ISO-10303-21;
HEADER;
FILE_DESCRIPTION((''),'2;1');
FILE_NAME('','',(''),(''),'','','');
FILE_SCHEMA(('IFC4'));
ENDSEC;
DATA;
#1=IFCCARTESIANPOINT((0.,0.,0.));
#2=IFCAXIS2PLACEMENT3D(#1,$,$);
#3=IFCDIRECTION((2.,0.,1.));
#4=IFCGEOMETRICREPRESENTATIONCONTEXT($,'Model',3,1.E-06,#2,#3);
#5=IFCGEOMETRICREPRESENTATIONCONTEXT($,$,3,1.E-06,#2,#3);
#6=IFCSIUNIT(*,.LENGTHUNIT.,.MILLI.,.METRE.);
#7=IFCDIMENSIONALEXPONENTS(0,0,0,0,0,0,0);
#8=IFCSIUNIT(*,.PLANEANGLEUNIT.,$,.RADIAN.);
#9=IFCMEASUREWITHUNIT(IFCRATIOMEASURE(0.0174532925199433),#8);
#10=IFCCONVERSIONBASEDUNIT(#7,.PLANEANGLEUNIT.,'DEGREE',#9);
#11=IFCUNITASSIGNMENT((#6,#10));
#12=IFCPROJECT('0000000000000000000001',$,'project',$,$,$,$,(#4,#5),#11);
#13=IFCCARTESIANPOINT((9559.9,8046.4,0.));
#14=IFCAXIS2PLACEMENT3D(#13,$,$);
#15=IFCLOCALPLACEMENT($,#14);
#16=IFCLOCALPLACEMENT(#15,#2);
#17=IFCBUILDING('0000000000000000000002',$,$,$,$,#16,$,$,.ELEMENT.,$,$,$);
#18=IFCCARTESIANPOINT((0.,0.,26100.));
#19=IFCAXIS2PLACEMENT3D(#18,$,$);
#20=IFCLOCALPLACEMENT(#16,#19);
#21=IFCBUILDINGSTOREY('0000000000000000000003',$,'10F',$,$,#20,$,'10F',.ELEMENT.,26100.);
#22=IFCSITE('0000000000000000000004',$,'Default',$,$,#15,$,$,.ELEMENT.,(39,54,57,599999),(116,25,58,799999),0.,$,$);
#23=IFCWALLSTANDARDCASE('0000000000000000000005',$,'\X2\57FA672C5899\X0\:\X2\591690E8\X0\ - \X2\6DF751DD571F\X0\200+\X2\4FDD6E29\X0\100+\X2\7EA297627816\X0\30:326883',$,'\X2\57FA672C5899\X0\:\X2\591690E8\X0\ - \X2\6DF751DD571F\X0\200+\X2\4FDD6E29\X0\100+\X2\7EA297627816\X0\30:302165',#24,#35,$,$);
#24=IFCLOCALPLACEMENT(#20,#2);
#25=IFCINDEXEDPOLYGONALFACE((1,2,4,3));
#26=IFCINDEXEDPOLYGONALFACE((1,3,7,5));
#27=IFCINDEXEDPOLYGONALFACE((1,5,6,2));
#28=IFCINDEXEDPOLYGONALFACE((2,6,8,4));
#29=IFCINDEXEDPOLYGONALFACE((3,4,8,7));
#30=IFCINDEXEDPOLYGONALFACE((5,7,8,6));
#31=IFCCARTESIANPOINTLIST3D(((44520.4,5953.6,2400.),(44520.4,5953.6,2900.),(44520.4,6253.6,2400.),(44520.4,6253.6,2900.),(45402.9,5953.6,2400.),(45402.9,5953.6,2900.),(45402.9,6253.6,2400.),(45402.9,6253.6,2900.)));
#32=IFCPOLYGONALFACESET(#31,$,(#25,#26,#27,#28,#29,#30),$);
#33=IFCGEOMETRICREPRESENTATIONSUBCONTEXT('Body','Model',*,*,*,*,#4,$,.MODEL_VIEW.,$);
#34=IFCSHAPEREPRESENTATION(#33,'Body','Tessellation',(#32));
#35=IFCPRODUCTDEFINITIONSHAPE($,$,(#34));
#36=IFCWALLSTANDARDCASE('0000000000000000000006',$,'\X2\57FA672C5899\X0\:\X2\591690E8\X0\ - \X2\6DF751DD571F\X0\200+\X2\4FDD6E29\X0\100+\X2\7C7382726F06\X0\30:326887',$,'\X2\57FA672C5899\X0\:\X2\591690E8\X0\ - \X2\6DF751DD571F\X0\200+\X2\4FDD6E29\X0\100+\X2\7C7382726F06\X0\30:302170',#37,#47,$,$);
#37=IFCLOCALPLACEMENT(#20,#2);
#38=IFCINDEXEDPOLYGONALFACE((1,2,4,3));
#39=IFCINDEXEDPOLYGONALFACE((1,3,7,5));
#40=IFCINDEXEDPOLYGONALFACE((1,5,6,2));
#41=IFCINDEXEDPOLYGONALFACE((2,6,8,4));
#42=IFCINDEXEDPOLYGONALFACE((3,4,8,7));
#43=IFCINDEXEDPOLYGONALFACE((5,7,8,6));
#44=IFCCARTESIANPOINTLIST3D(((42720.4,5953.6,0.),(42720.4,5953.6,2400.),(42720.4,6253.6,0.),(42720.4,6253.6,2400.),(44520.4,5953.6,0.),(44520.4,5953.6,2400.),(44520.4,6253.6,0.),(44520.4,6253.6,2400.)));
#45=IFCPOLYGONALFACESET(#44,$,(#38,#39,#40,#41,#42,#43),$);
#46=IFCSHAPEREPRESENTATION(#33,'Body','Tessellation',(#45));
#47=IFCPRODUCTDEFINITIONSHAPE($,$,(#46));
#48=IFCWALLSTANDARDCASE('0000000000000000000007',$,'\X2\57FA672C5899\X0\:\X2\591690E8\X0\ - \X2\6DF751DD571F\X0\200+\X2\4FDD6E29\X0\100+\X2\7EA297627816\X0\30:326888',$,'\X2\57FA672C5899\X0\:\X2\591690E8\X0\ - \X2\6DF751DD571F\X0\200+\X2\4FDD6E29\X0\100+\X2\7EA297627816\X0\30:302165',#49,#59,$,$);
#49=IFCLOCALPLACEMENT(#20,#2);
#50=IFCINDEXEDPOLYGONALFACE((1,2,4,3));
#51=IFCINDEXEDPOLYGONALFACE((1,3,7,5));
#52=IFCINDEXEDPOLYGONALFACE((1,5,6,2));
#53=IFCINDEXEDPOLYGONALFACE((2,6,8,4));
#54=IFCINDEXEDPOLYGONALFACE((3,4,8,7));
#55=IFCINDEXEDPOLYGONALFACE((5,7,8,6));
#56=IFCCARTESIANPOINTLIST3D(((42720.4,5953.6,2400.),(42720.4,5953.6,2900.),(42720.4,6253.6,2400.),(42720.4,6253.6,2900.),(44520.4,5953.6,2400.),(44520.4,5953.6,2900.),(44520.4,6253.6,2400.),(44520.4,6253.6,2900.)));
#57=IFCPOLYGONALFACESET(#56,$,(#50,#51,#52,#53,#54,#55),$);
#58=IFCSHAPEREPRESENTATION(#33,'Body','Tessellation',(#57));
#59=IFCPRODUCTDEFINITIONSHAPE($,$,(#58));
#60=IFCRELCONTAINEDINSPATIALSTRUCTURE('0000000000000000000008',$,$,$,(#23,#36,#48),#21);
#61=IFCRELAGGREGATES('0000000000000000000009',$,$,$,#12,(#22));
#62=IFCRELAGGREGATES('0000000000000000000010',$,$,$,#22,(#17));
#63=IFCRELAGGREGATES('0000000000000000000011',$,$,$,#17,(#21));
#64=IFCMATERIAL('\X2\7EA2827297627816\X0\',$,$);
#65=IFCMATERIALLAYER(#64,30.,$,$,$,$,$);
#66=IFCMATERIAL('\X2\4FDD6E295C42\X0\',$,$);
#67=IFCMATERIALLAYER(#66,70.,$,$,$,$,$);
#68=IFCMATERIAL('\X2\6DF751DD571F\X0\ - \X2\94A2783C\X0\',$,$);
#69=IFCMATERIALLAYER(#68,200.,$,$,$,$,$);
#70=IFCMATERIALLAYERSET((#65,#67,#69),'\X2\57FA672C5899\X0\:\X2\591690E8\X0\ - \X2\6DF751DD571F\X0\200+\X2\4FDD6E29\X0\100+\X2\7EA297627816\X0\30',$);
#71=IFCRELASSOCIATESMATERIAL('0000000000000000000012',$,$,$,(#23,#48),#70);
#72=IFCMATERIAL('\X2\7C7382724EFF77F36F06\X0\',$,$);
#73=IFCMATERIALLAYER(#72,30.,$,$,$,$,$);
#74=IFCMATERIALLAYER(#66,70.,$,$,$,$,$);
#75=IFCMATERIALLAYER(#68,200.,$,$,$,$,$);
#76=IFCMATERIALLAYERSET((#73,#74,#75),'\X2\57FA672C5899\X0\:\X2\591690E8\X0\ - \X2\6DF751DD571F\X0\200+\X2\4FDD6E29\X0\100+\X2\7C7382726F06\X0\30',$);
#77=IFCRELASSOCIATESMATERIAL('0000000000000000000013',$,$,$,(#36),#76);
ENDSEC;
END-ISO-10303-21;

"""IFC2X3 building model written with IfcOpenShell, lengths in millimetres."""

from ifc_helpers import new_model, entity, si_unit, converted_unit, direction, frame, frame_2d, origin, place, context, subcontext, project, spatial, rectangle, extrude, material, layer, layer_set, layer_usage, element, save


model = new_model("IFC2X3")

# Units and contexts
model_context = context("Model", 3, precision=1e-06, world=origin(), true_north=direction((2.0, 0.0, 1.0)))
context_of_model = context(None, 3, precision=1e-06, world=origin(), true_north=direction((2.0, 0.0, 1.0)))
body_context = subcontext(model_context, "Body", "Model", "MODEL_VIEW")
ifc_project = project(units=[si_unit("LENGTHUNIT", "METRE", prefix="MILLI"), converted_unit("PLANEANGLEUNIT", "DEGREE", entity("IfcRatioMeasure", 0.0174532925199433), si_unit("PLANEANGLEUNIT", "RADIAN"), dimensions=[0, 0, 0, 0, 0, 0, 0])], contexts=[model_context, context_of_model])

# Site, building, storey
site_placement = place(None, frame((9559.9, 8046.4, 0.0)))
site = spatial("IfcSite", under=ifc_project, at=site_placement, Name="Default", CompositionType="ELEMENT", RefLatitude=(39, 54, 57, 599999), RefLongitude=(116, 25, 58, 799999), RefElevation=0.0)
building_placement = place(site_placement, origin())
building = spatial("IfcBuilding", under=site, at=building_placement, CompositionType="ELEMENT")
storey_placement = place(building_placement, frame((0.0, 0.0, 26100.0)))
storey = spatial("IfcBuildingStorey", under=building, at=storey_placement, Name="10F", LongName="10F", CompositionType="ELEMENT", Elevation=26100.0)

# Shared definitions
ifc_material_1 = material(Name="红色面砖")
ifc_layer_1 = layer(ifc_material_1, 30.0)
ifc_material_2 = material(Name="保温层")
ifc_layer_2 = layer(ifc_material_2, 70.0)
ifc_material_3 = material(Name="混凝土 - 钢砼")
ifc_layer_3 = layer(ifc_material_3, 200.0)
ifc_layer_set_1 = layer_set([ifc_layer_1, ifc_layer_2, ifc_layer_3], Name="基本墙:外部 - 混凝土200+保温100+红面砖30")

# Shared definitions
ifc_material_4 = material(Name="米色仿石漆")
ifc_layer_4 = layer(ifc_material_4, 30.0)
ifc_layer_5 = layer(ifc_material_2, 70.0)
ifc_layer_6 = layer(ifc_material_3, 200.0)
ifc_layer_set_2 = layer_set([ifc_layer_4, ifc_layer_5, ifc_layer_6], Name="基本墙:外部 - 混凝土200+保温100+米色漆30")

# Walls
ifc_layer_usage_1 = layer_usage(ifc_layer_set_1, "AXIS2", "NEGATIVE", 150.0)
wall_1_placement = place(storey_placement, frame((44520.4, 6103.6, 2400.0)))
element("IfcWallStandardCase", 1, at=wall_1_placement, inside=storey, material=ifc_layer_usage_1, Name="基本墙:外部 - 混凝土200+保温100+红面砖30:326883", ObjectType="基本墙:外部 - 混凝土200+保温100+红面砖30:302165", context=body_context, shape_type="SweptSolid", body=[
    extrude(rectangle(XDim=882.5, YDim=300.0, at=frame_2d((441.2, 0.0), x_axis=(-1.0, 0.0))), origin(), (0.0, 0.0, 1.0), 500.0),
])
ifc_layer_usage_2 = layer_usage(ifc_layer_set_2, "AXIS2", "NEGATIVE", 150.0)
wall_2_placement = place(storey_placement, frame((42720.4, 6103.6, 0.0)))
element("IfcWallStandardCase", 2, at=wall_2_placement, inside=storey, material=ifc_layer_usage_2, Name="基本墙:外部 - 混凝土200+保温100+米色漆30:326887", ObjectType="基本墙:外部 - 混凝土200+保温100+米色漆30:302170", context=body_context, shape_type="SweptSolid", body=[
    extrude(rectangle(XDim=1800.0, YDim=300.0, at=frame_2d((900.0, 0.0), x_axis=(-1.0, 0.0))), origin(), (0.0, 0.0, 1.0), 2400.0),
])
ifc_layer_usage_3 = layer_usage(ifc_layer_set_1, "AXIS2", "NEGATIVE", 150.0)
wall_3_placement = place(storey_placement, frame((42720.4, 6103.6, 2400.0)))
element("IfcWallStandardCase", 3, at=wall_3_placement, inside=storey, material=ifc_layer_usage_3, Name="基本墙:外部 - 混凝土200+保温100+红面砖30:326888", ObjectType="基本墙:外部 - 混凝土200+保温100+红面砖30:302165", context=body_context, shape_type="SweptSolid", body=[
    extrude(rectangle(XDim=1800.0, YDim=300.0, at=frame_2d((900.0, 0.0), x_axis=(-1.0, 0.0))), origin(), (0.0, 0.0, 1.0), 500.0),
])

save(model, "model.ifc")
